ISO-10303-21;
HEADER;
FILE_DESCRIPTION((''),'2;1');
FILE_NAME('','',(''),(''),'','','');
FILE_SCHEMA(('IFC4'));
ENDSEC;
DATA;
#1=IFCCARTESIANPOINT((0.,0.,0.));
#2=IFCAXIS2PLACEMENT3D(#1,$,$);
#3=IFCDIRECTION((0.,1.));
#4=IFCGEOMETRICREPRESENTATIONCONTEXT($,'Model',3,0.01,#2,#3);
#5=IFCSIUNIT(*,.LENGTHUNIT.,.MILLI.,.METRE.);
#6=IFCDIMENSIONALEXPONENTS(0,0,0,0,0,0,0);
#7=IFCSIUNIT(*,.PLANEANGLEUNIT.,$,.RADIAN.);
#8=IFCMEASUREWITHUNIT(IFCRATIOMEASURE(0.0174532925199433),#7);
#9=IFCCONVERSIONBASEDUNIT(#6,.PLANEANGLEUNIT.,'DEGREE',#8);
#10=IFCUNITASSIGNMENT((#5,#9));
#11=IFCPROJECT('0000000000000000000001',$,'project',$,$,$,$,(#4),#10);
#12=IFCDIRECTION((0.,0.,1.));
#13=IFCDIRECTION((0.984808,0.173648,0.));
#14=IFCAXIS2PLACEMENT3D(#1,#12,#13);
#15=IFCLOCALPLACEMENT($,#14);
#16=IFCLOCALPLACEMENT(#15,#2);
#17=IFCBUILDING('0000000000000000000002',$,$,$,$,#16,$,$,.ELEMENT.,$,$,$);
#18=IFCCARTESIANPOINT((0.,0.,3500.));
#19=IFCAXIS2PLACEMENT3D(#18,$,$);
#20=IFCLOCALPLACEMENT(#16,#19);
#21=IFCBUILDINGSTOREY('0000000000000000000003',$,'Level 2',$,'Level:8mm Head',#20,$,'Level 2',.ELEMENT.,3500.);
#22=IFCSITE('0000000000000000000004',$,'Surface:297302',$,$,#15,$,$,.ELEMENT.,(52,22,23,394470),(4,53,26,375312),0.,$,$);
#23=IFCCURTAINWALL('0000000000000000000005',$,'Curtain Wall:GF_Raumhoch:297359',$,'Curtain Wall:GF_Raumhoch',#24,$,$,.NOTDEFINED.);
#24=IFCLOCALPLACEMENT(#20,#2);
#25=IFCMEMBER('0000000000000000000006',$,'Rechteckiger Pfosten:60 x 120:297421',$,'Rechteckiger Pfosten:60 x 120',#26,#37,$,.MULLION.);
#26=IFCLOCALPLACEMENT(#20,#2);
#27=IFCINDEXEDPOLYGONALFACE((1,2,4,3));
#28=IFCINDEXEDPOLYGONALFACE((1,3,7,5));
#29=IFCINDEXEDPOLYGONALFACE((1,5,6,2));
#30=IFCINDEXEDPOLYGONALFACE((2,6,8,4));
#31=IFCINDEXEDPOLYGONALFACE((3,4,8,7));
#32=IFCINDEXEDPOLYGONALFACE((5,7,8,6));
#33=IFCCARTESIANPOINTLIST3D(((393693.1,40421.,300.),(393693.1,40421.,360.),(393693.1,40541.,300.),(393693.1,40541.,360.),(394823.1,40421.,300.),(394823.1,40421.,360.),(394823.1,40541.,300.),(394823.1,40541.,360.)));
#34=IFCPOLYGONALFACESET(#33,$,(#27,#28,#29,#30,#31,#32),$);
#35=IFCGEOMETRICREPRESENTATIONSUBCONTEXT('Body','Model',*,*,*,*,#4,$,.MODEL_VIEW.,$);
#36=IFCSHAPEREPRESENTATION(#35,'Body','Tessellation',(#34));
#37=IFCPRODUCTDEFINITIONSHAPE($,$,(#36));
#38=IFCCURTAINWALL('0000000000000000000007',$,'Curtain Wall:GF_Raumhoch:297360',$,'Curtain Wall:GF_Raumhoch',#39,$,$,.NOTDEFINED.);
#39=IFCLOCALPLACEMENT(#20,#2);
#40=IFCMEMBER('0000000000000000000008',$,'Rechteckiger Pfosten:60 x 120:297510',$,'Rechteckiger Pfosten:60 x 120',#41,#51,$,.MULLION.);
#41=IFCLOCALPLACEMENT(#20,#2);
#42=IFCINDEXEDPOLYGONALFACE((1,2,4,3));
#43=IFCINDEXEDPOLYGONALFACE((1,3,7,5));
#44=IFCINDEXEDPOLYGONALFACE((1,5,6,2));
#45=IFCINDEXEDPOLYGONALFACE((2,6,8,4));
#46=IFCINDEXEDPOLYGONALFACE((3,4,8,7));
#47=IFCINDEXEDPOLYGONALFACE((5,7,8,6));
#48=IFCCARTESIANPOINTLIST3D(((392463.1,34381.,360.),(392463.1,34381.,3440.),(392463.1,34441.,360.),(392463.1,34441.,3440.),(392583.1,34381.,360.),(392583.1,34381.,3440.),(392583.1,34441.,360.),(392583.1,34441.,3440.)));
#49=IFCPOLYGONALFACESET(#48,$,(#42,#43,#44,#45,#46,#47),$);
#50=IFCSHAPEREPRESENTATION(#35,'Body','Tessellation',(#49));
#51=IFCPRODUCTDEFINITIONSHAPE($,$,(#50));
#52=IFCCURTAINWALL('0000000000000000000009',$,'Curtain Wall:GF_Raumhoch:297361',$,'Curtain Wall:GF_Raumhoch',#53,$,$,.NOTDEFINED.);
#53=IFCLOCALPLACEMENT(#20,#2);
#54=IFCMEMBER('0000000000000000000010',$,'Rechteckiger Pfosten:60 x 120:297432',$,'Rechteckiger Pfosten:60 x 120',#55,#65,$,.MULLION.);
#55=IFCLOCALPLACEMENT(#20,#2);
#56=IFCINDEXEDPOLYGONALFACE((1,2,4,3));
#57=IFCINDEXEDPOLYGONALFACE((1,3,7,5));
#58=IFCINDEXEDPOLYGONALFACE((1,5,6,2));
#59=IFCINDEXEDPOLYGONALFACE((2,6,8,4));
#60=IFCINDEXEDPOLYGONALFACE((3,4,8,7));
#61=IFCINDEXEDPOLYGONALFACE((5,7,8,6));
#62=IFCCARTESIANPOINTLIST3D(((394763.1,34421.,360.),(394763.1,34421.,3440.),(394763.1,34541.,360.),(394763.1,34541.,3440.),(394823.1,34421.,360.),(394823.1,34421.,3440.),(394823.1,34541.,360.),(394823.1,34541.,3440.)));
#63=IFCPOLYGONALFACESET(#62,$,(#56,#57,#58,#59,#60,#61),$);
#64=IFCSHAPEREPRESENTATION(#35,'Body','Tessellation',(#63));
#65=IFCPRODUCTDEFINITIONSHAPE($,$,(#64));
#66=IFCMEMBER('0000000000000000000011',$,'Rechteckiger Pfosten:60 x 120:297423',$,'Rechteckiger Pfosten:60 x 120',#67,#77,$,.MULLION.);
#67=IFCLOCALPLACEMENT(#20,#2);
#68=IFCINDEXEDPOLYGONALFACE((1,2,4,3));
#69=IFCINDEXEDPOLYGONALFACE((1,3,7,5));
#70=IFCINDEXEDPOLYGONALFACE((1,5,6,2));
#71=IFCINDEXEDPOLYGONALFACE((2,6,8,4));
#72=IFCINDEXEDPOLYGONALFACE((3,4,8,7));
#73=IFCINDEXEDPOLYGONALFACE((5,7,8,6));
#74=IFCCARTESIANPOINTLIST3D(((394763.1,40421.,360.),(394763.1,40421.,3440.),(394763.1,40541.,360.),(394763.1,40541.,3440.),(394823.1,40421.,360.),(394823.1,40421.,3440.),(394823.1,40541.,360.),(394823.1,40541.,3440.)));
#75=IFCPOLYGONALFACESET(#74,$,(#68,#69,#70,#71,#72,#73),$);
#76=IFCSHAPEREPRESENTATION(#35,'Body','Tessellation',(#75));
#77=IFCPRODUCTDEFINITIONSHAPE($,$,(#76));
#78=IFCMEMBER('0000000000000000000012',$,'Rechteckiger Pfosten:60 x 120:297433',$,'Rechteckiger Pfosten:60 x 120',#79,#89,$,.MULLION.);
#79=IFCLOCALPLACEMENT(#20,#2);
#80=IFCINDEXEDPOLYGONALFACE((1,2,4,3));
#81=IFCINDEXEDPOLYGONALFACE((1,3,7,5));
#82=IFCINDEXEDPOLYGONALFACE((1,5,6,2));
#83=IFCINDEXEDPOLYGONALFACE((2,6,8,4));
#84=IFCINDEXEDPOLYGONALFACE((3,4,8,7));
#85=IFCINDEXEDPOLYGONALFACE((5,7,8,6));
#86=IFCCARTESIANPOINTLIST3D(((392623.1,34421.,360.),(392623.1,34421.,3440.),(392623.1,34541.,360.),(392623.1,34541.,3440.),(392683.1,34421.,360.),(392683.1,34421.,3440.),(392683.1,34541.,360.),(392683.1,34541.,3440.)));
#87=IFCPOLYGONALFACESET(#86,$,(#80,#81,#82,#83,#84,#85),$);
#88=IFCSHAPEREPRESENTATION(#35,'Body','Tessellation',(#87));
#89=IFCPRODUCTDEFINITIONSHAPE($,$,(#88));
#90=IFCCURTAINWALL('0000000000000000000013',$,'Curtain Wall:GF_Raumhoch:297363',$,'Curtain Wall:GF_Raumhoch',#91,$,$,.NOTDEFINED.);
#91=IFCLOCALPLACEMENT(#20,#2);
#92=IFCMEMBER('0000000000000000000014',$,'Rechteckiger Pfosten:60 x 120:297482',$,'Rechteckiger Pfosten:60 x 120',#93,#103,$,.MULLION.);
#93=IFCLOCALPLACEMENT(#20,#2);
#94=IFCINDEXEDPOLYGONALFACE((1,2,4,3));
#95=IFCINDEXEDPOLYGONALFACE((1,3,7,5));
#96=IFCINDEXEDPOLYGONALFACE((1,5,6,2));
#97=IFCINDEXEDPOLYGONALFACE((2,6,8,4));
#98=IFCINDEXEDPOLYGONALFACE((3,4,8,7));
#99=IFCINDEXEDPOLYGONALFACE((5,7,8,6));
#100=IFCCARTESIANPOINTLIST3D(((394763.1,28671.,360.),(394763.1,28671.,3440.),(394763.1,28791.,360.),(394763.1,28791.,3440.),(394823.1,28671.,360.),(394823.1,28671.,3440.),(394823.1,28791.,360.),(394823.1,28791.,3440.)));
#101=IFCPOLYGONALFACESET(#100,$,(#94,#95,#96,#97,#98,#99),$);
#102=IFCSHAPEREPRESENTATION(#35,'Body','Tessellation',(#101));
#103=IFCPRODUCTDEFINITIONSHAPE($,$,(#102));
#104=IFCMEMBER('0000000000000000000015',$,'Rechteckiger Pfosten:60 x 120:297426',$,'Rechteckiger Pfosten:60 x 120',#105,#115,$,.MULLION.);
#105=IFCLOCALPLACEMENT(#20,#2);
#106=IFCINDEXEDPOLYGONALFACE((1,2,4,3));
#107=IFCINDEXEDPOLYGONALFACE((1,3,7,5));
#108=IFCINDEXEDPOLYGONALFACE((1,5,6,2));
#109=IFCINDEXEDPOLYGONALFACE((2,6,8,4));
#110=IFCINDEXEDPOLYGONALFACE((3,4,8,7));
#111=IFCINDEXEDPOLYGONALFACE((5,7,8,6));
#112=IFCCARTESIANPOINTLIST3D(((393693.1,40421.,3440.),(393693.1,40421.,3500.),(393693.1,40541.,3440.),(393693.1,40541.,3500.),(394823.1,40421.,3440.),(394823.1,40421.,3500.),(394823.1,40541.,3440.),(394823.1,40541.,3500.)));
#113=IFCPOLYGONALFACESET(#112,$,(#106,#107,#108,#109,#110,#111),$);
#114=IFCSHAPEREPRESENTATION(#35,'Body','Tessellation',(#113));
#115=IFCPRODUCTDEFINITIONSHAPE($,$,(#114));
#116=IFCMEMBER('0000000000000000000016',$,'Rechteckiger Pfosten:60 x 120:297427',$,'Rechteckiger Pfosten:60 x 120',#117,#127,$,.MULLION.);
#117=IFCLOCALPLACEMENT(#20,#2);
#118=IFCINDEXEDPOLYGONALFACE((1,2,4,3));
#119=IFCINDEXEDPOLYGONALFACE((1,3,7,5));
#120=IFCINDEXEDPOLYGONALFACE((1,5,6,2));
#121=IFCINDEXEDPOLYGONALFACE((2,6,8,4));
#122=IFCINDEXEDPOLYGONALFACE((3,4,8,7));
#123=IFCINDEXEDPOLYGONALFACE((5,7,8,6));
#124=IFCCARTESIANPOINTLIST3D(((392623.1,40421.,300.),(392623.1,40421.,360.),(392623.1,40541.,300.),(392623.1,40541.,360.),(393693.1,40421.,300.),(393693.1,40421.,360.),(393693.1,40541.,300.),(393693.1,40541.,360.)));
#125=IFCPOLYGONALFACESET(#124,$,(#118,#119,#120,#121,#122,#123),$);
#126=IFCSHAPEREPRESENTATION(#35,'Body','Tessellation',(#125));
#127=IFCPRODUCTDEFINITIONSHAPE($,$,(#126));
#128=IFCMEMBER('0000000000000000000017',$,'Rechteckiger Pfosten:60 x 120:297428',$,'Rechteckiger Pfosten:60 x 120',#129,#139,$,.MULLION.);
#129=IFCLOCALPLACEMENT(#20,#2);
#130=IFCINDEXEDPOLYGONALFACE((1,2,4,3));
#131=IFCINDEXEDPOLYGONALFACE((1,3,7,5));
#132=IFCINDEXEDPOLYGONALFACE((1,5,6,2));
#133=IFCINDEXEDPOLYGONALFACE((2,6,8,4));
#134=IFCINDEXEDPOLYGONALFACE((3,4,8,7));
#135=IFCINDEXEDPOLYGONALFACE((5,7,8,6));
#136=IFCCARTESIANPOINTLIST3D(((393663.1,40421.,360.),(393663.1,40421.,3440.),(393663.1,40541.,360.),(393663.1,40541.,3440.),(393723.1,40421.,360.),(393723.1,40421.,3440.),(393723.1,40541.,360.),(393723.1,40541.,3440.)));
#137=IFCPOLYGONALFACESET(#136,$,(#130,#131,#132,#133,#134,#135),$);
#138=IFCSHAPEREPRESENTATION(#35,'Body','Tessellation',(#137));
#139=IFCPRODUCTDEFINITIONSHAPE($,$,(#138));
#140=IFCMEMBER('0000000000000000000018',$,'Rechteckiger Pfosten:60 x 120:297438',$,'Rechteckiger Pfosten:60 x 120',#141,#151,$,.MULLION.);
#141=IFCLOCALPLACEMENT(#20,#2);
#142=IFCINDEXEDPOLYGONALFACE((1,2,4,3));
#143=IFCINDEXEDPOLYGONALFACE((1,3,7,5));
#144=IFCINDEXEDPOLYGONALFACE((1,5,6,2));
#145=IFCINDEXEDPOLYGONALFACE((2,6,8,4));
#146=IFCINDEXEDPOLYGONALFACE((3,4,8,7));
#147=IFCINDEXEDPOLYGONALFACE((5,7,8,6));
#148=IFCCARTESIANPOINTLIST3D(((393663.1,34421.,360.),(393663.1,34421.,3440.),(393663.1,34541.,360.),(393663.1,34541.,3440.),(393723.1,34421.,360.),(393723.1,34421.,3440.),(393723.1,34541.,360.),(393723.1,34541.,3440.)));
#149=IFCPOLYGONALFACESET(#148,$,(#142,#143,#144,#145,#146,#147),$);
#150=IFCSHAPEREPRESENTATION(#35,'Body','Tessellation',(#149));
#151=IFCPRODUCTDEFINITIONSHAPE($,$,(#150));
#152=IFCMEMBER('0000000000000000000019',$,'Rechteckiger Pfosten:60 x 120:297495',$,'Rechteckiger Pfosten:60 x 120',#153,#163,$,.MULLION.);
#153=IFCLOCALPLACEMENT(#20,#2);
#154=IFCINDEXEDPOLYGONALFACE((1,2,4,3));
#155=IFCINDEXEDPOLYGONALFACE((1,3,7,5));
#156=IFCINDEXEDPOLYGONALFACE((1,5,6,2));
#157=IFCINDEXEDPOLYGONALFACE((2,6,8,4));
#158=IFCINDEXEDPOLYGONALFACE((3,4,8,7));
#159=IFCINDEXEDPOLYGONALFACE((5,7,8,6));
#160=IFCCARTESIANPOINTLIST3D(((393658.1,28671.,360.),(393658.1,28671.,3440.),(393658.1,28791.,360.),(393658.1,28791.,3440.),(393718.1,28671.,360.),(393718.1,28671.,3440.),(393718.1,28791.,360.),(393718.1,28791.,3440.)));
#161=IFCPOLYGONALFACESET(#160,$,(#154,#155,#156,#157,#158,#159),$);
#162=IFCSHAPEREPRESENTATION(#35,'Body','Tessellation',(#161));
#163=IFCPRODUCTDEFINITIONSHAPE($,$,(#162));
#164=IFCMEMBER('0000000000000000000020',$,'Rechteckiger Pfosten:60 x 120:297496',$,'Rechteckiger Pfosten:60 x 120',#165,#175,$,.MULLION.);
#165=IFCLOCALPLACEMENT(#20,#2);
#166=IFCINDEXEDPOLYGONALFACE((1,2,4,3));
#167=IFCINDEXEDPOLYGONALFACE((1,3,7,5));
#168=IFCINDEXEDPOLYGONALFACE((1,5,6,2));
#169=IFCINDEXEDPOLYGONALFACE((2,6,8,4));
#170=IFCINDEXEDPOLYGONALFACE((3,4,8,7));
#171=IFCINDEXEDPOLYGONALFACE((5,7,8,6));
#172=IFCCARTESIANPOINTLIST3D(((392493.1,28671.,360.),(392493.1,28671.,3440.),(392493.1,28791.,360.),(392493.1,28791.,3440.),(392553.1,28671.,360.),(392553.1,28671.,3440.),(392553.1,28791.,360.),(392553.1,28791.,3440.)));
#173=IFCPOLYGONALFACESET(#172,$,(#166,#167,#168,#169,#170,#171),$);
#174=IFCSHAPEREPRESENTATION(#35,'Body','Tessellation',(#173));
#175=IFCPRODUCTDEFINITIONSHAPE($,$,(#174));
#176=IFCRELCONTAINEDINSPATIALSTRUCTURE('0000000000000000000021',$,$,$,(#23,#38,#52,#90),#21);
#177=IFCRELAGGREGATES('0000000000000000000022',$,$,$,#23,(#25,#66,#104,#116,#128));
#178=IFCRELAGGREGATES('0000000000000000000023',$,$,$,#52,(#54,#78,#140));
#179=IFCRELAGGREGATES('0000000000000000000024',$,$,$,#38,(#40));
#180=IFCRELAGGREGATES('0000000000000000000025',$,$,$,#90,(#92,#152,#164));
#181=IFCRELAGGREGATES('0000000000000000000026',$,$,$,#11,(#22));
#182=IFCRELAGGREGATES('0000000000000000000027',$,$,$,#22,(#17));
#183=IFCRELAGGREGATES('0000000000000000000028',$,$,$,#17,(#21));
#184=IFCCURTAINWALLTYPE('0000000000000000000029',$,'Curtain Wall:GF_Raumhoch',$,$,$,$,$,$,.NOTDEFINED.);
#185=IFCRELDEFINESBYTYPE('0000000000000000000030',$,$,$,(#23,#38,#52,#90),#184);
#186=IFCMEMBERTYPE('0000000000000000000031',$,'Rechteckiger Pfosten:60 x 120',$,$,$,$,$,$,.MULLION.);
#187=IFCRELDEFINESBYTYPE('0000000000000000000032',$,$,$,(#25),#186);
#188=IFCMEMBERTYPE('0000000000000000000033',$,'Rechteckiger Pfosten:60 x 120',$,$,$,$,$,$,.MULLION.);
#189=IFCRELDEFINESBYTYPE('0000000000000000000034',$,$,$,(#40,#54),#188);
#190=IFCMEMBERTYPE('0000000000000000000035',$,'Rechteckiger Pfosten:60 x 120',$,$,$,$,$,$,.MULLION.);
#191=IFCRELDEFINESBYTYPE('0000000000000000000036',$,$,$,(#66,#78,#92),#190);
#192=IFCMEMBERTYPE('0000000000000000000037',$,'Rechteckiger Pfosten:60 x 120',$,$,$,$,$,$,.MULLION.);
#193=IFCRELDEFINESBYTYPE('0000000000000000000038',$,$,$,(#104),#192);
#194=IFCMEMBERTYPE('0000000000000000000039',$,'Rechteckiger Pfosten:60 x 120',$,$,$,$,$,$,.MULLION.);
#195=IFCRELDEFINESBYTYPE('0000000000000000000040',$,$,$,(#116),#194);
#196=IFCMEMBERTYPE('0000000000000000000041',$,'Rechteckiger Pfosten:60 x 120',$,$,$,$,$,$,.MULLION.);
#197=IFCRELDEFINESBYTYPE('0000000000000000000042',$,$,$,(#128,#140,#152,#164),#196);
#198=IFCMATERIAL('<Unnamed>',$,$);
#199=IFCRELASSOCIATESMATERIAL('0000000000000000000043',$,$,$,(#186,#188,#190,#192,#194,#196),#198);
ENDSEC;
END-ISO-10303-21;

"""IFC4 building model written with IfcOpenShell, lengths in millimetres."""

from ifc_helpers import new_model, entity, si_unit, converted_unit, direction, frame, origin, place, context, subcontext, project, spatial, indexed_curve, outline, extrude, source, transform, mapped, material, type_object, type_shapes, element, aggregate, save


model = new_model("IFC4")

# Units and contexts
model_context = context("Model", 3, precision=0.01, world=origin(), true_north=direction((0.0, 1.0)))
body_context = subcontext(model_context, "Body", "Model", "MODEL_VIEW")
ifc_project = project(units=[si_unit("LENGTHUNIT", "METRE", prefix="MILLI"), converted_unit("PLANEANGLEUNIT", "DEGREE", entity("IfcRatioMeasure", 0.0174532925199433), si_unit("PLANEANGLEUNIT", "RADIAN"), dimensions=[0, 0, 0, 0, 0, 0, 0])], contexts=[model_context])

# Site, building, storey
site_placement = place(None, frame((0.0, 0.0, 0.0), z_axis=(0.0, 0.0, 1.0), x_axis=(0.984808, 0.173648, 0.0)))
site = spatial("IfcSite", under=ifc_project, at=site_placement, Name="Surface:297302", CompositionType="ELEMENT", RefLatitude=(52, 22, 23, 394470), RefLongitude=(4, 53, 26, 375312), RefElevation=0.0)
building_placement = place(site_placement, origin())
building = spatial("IfcBuilding", under=site, at=building_placement, CompositionType="ELEMENT")
storey_placement = place(building_placement, frame((0.0, 0.0, 3500.0)))
storey = spatial("IfcBuildingStorey", under=building, at=storey_placement, Name="Level 2", ObjectType="Level:8mm Head", LongName="Level 2", CompositionType="ELEMENT", Elevation=3500.0)

# Curtain walls, members
curtain_wall_type = type_object("IfcCurtainWallType", Name="Curtain Wall:GF_Raumhoch", PredefinedType="NOTDEFINED")
curtain_wall_1_placement = place(storey_placement, frame((0.0, 0.0, -3500.0)))
curtain_wall_1 = element("IfcCurtainWall", 1, at=curtain_wall_1_placement, inside=storey, type_object=curtain_wall_type, Name="Curtain Wall:GF_Raumhoch:297359", ObjectType="Curtain Wall:GF_Raumhoch", PredefinedType="NOTDEFINED")
ifc_material_1 = material(Name="<Unnamed>")
member_type_1 = type_object("IfcMemberType", Name="Rechteckiger Pfosten:60 x 120", PredefinedType="MULLION", material=ifc_material_1)
shared_shape_1 = source(origin(), body_context, "Body", "SweptSolid", [
    extrude(outline(indexed_curve([(-60.0, -30.0), (60.0, -30.0), (60.0, 30.0), (-60.0, 30.0), (-60.0, -30.0)], self_intersect=False)), frame((-30.0, 0.0, -1130.0), z_axis=(0.0, 0.0, 1.0), x_axis=(0.0, -1.0, 0.0)), (0.0, 0.0, 1.0), 1130.0),
])
type_shapes(member_type_1, [shared_shape_1])
member_1_placement = place(curtain_wall_1_placement, frame((394823.1, 40481.0, 3800.0), z_axis=(1.0, 0.0, 0.0), x_axis=(0.0, 0.0, -1.0)))
member_1 = element("IfcMember", 2, at=member_1_placement, type_object=member_type_1, Name="Rechteckiger Pfosten:60 x 120:297421", ObjectType="Rechteckiger Pfosten:60 x 120", PredefinedType="MULLION", context=body_context, shape_type="MappedRepresentation", body=[
    mapped(shared_shape_1, transform((0.0, 0.0, 0.0), scale=1.0)),
])
curtain_wall_2_placement = place(storey_placement, frame((0.0, 0.0, -3500.0)))
curtain_wall_2 = element("IfcCurtainWall", 3, at=curtain_wall_2_placement, inside=storey, type_object=curtain_wall_type, Name="Curtain Wall:GF_Raumhoch:297360", ObjectType="Curtain Wall:GF_Raumhoch", PredefinedType="NOTDEFINED")
member_type_2 = type_object("IfcMemberType", Name="Rechteckiger Pfosten:60 x 120", PredefinedType="MULLION", material=ifc_material_1)
shared_shape_2 = source(origin(), body_context, "Body", "SweptSolid", [
    extrude(outline(indexed_curve([(-60.0, -30.0), (60.0, -30.0), (60.0, 30.0), (-60.0, 30.0), (-60.0, -30.0)], self_intersect=False)), frame((-30.0, 0.0, -3080.0), z_axis=(0.0, 0.0, 1.0), x_axis=(0.0, -1.0, 0.0)), (0.0, 0.0, 1.0), 3080.0),
])
type_shapes(member_type_2, [shared_shape_2])
member_2_placement = place(curtain_wall_2_placement, frame((392523.1, 34381.0, 3860.0), z_axis=(0.0, 0.0, -1.0), x_axis=(0.0, -1.0, 0.0)))
member_2 = element("IfcMember", 4, at=member_2_placement, type_object=member_type_2, Name="Rechteckiger Pfosten:60 x 120:297510", ObjectType="Rechteckiger Pfosten:60 x 120", PredefinedType="MULLION", context=body_context, shape_type="MappedRepresentation", body=[
    mapped(shared_shape_2, transform((0.0, 0.0, 0.0), scale=1.0)),
])
curtain_wall_3_placement = place(storey_placement, frame((0.0, 0.0, -3500.0)))
curtain_wall_3 = element("IfcCurtainWall", 5, at=curtain_wall_3_placement, inside=storey, type_object=curtain_wall_type, Name="Curtain Wall:GF_Raumhoch:297361", ObjectType="Curtain Wall:GF_Raumhoch", PredefinedType="NOTDEFINED")
member_3_placement = place(curtain_wall_3_placement, frame((394823.1, 34481.0, 3860.0), z_axis=(0.0, 0.0, -1.0), x_axis=(1.0, 0.0, 0.0)))
member_3 = element("IfcMember", 6, at=member_3_placement, type_object=member_type_2, Name="Rechteckiger Pfosten:60 x 120:297432", ObjectType="Rechteckiger Pfosten:60 x 120", PredefinedType="MULLION", context=body_context, shape_type="MappedRepresentation", body=[
    mapped(shared_shape_2, transform((0.0, 0.0, 0.0), scale=1.0)),
])

# Members
member_type_3 = type_object("IfcMemberType", Name="Rechteckiger Pfosten:60 x 120", PredefinedType="MULLION", material=ifc_material_1)
shared_shape_3 = source(origin(), body_context, "Body", "SweptSolid", [
    extrude(outline(indexed_curve([(-60.0, -30.0), (60.0, -30.0), (60.0, 30.0), (-60.0, 30.0), (-60.0, -30.0)], self_intersect=False)), frame((-30.0, 0.0, -3080.0), z_axis=(0.0, 0.0, 1.0), x_axis=(0.0, -1.0, 0.0)), (0.0, 0.0, 1.0), 3080.0),
])
type_shapes(member_type_3, [shared_shape_3])
member_4_placement = place(curtain_wall_1_placement, frame((394823.1, 40481.0, 6940.0)))
member_4 = element("IfcMember", 7, at=member_4_placement, type_object=member_type_3, Name="Rechteckiger Pfosten:60 x 120:297423", ObjectType="Rechteckiger Pfosten:60 x 120", PredefinedType="MULLION", context=body_context, shape_type="MappedRepresentation", body=[
    mapped(shared_shape_3, transform((0.0, 0.0, 0.0), scale=1.0)),
])
member_5_placement = place(curtain_wall_3_placement, frame((392623.1, 34481.0, 6940.0), z_axis=(0.0, 0.0, 1.0), x_axis=(-1.0, 0.0, 0.0)))
member_5 = element("IfcMember", 8, at=member_5_placement, type_object=member_type_3, Name="Rechteckiger Pfosten:60 x 120:297433", ObjectType="Rechteckiger Pfosten:60 x 120", PredefinedType="MULLION", context=body_context, shape_type="MappedRepresentation", body=[
    mapped(shared_shape_3, transform((0.0, 0.0, 0.0), scale=1.0)),
])

# Curtain wall, member
curtain_wall_4_placement = place(storey_placement, frame((0.0, 0.0, -3500.0)))
curtain_wall_4 = element("IfcCurtainWall", 9, at=curtain_wall_4_placement, inside=storey, type_object=curtain_wall_type, Name="Curtain Wall:GF_Raumhoch:297363", ObjectType="Curtain Wall:GF_Raumhoch", PredefinedType="NOTDEFINED")
member_6_placement = place(curtain_wall_4_placement, frame((394823.1, 28731.0, 6940.0)))
member_6 = element("IfcMember", 10, at=member_6_placement, type_object=member_type_3, Name="Rechteckiger Pfosten:60 x 120:297482", ObjectType="Rechteckiger Pfosten:60 x 120", PredefinedType="MULLION", context=body_context, shape_type="MappedRepresentation", body=[
    mapped(shared_shape_3, transform((0.0, 0.0, 0.0), scale=1.0)),
])

# Members
member_type_4 = type_object("IfcMemberType", Name="Rechteckiger Pfosten:60 x 120", PredefinedType="MULLION", material=ifc_material_1)
shared_shape_4 = source(origin(), body_context, "Body", "SweptSolid", [
    extrude(outline(indexed_curve([(-60.0, -30.0), (60.0, -30.0), (60.0, 30.0), (-60.0, 30.0), (-60.0, -30.0)], self_intersect=False)), frame((-30.0, 0.0, -1130.0), z_axis=(0.0, 0.0, 1.0), x_axis=(0.0, -1.0, 0.0)), (0.0, 0.0, 1.0), 1130.0),
])
type_shapes(member_type_4, [shared_shape_4])
member_7_placement = place(curtain_wall_1_placement, frame((393693.1, 40481.0, 7000.0), z_axis=(-1.0, 0.0, 0.0), x_axis=(0.0, 0.0, 1.0)))
member_7 = element("IfcMember", 11, at=member_7_placement, type_object=member_type_4, Name="Rechteckiger Pfosten:60 x 120:297426", ObjectType="Rechteckiger Pfosten:60 x 120", PredefinedType="MULLION", context=body_context, shape_type="MappedRepresentation", body=[
    mapped(shared_shape_4, transform((0.0, 0.0, 0.0), scale=1.0)),
])
member_type_5 = type_object("IfcMemberType", Name="Rechteckiger Pfosten:60 x 120", PredefinedType="MULLION", material=ifc_material_1)
shared_shape_5 = source(origin(), body_context, "Body", "SweptSolid", [
    extrude(outline(indexed_curve([(-60.0, -30.0), (60.0, -30.0), (60.0, 30.0), (-60.0, 30.0), (-60.0, -30.0)], self_intersect=False)), frame((-30.0, 0.0, -1070.0), z_axis=(0.0, 0.0, 1.0), x_axis=(0.0, -1.0, 0.0)), (0.0, 0.0, 1.0), 1070.0),
])
type_shapes(member_type_5, [shared_shape_5])
member_8_placement = place(curtain_wall_1_placement, frame((393693.1, 40481.0, 3800.0), z_axis=(1.0, 0.0, 0.0), x_axis=(0.0, 0.0, -1.0)))
member_8 = element("IfcMember", 12, at=member_8_placement, type_object=member_type_5, Name="Rechteckiger Pfosten:60 x 120:297427", ObjectType="Rechteckiger Pfosten:60 x 120", PredefinedType="MULLION", context=body_context, shape_type="MappedRepresentation", body=[
    mapped(shared_shape_5, transform((0.0, 0.0, 0.0), scale=1.0)),
])
member_type_6 = type_object("IfcMemberType", Name="Rechteckiger Pfosten:60 x 120", PredefinedType="MULLION", material=ifc_material_1)
shared_shape_6 = source(origin(), body_context, "Body", "SweptSolid", [
    extrude(outline(indexed_curve([(-60.0, -30.0), (60.0, -30.0), (60.0, 30.0), (-60.0, 30.0), (-60.0, -30.0)], self_intersect=False)), frame((0.0, 0.0, -3080.0), z_axis=(0.0, 0.0, 1.0), x_axis=(0.0, -1.0, 0.0)), (0.0, 0.0, 1.0), 3080.0),
])
type_shapes(member_type_6, [shared_shape_6])
member_9_placement = place(curtain_wall_1_placement, frame((393693.1, 40481.0, 3860.0), z_axis=(0.0, 0.0, -1.0), x_axis=(-1.0, 0.0, 0.0)))
member_9 = element("IfcMember", 13, at=member_9_placement, type_object=member_type_6, Name="Rechteckiger Pfosten:60 x 120:297428", ObjectType="Rechteckiger Pfosten:60 x 120", PredefinedType="MULLION", context=body_context, shape_type="MappedRepresentation", body=[
    mapped(shared_shape_6, transform((0.0, 0.0, 0.0), scale=1.0)),
])
member_10_placement = place(curtain_wall_3_placement, frame((393693.1, 34481.0, 3860.0), z_axis=(0.0, 0.0, -1.0), x_axis=(1.0, 0.0, 0.0)))
member_10 = element("IfcMember", 14, at=member_10_placement, type_object=member_type_6, Name="Rechteckiger Pfosten:60 x 120:297438", ObjectType="Rechteckiger Pfosten:60 x 120", PredefinedType="MULLION", context=body_context, shape_type="MappedRepresentation", body=[
    mapped(shared_shape_6, transform((0.0, 0.0, 0.0), scale=1.0)),
])
member_11_placement = place(curtain_wall_4_placement, frame((393688.1, 28731.0, 3860.0), z_axis=(0.0, 0.0, -1.0), x_axis=(-1.0, 0.0, 0.0)))
member_11 = element("IfcMember", 15, at=member_11_placement, type_object=member_type_6, Name="Rechteckiger Pfosten:60 x 120:297495", ObjectType="Rechteckiger Pfosten:60 x 120", PredefinedType="MULLION", context=body_context, shape_type="MappedRepresentation", body=[
    mapped(shared_shape_6, transform((0.0, 0.0, 0.0), scale=1.0)),
])
member_12_placement = place(curtain_wall_4_placement, frame((392523.1, 28731.0, 3860.0), z_axis=(0.0, 0.0, -1.0), x_axis=(-1.0, 0.0, 0.0)))
member_12 = element("IfcMember", 16, at=member_12_placement, type_object=member_type_6, Name="Rechteckiger Pfosten:60 x 120:297496", ObjectType="Rechteckiger Pfosten:60 x 120", PredefinedType="MULLION", context=body_context, shape_type="MappedRepresentation", body=[
    mapped(shared_shape_6, transform((0.0, 0.0, 0.0), scale=1.0)),
])

aggregate(curtain_wall_1, [member_1, member_4, member_7, member_8, member_9])
aggregate(curtain_wall_3, [member_3, member_5, member_10])
aggregate(curtain_wall_2, [member_2])
aggregate(curtain_wall_4, [member_6, member_11, member_12])

save(model, "model.ifc")
